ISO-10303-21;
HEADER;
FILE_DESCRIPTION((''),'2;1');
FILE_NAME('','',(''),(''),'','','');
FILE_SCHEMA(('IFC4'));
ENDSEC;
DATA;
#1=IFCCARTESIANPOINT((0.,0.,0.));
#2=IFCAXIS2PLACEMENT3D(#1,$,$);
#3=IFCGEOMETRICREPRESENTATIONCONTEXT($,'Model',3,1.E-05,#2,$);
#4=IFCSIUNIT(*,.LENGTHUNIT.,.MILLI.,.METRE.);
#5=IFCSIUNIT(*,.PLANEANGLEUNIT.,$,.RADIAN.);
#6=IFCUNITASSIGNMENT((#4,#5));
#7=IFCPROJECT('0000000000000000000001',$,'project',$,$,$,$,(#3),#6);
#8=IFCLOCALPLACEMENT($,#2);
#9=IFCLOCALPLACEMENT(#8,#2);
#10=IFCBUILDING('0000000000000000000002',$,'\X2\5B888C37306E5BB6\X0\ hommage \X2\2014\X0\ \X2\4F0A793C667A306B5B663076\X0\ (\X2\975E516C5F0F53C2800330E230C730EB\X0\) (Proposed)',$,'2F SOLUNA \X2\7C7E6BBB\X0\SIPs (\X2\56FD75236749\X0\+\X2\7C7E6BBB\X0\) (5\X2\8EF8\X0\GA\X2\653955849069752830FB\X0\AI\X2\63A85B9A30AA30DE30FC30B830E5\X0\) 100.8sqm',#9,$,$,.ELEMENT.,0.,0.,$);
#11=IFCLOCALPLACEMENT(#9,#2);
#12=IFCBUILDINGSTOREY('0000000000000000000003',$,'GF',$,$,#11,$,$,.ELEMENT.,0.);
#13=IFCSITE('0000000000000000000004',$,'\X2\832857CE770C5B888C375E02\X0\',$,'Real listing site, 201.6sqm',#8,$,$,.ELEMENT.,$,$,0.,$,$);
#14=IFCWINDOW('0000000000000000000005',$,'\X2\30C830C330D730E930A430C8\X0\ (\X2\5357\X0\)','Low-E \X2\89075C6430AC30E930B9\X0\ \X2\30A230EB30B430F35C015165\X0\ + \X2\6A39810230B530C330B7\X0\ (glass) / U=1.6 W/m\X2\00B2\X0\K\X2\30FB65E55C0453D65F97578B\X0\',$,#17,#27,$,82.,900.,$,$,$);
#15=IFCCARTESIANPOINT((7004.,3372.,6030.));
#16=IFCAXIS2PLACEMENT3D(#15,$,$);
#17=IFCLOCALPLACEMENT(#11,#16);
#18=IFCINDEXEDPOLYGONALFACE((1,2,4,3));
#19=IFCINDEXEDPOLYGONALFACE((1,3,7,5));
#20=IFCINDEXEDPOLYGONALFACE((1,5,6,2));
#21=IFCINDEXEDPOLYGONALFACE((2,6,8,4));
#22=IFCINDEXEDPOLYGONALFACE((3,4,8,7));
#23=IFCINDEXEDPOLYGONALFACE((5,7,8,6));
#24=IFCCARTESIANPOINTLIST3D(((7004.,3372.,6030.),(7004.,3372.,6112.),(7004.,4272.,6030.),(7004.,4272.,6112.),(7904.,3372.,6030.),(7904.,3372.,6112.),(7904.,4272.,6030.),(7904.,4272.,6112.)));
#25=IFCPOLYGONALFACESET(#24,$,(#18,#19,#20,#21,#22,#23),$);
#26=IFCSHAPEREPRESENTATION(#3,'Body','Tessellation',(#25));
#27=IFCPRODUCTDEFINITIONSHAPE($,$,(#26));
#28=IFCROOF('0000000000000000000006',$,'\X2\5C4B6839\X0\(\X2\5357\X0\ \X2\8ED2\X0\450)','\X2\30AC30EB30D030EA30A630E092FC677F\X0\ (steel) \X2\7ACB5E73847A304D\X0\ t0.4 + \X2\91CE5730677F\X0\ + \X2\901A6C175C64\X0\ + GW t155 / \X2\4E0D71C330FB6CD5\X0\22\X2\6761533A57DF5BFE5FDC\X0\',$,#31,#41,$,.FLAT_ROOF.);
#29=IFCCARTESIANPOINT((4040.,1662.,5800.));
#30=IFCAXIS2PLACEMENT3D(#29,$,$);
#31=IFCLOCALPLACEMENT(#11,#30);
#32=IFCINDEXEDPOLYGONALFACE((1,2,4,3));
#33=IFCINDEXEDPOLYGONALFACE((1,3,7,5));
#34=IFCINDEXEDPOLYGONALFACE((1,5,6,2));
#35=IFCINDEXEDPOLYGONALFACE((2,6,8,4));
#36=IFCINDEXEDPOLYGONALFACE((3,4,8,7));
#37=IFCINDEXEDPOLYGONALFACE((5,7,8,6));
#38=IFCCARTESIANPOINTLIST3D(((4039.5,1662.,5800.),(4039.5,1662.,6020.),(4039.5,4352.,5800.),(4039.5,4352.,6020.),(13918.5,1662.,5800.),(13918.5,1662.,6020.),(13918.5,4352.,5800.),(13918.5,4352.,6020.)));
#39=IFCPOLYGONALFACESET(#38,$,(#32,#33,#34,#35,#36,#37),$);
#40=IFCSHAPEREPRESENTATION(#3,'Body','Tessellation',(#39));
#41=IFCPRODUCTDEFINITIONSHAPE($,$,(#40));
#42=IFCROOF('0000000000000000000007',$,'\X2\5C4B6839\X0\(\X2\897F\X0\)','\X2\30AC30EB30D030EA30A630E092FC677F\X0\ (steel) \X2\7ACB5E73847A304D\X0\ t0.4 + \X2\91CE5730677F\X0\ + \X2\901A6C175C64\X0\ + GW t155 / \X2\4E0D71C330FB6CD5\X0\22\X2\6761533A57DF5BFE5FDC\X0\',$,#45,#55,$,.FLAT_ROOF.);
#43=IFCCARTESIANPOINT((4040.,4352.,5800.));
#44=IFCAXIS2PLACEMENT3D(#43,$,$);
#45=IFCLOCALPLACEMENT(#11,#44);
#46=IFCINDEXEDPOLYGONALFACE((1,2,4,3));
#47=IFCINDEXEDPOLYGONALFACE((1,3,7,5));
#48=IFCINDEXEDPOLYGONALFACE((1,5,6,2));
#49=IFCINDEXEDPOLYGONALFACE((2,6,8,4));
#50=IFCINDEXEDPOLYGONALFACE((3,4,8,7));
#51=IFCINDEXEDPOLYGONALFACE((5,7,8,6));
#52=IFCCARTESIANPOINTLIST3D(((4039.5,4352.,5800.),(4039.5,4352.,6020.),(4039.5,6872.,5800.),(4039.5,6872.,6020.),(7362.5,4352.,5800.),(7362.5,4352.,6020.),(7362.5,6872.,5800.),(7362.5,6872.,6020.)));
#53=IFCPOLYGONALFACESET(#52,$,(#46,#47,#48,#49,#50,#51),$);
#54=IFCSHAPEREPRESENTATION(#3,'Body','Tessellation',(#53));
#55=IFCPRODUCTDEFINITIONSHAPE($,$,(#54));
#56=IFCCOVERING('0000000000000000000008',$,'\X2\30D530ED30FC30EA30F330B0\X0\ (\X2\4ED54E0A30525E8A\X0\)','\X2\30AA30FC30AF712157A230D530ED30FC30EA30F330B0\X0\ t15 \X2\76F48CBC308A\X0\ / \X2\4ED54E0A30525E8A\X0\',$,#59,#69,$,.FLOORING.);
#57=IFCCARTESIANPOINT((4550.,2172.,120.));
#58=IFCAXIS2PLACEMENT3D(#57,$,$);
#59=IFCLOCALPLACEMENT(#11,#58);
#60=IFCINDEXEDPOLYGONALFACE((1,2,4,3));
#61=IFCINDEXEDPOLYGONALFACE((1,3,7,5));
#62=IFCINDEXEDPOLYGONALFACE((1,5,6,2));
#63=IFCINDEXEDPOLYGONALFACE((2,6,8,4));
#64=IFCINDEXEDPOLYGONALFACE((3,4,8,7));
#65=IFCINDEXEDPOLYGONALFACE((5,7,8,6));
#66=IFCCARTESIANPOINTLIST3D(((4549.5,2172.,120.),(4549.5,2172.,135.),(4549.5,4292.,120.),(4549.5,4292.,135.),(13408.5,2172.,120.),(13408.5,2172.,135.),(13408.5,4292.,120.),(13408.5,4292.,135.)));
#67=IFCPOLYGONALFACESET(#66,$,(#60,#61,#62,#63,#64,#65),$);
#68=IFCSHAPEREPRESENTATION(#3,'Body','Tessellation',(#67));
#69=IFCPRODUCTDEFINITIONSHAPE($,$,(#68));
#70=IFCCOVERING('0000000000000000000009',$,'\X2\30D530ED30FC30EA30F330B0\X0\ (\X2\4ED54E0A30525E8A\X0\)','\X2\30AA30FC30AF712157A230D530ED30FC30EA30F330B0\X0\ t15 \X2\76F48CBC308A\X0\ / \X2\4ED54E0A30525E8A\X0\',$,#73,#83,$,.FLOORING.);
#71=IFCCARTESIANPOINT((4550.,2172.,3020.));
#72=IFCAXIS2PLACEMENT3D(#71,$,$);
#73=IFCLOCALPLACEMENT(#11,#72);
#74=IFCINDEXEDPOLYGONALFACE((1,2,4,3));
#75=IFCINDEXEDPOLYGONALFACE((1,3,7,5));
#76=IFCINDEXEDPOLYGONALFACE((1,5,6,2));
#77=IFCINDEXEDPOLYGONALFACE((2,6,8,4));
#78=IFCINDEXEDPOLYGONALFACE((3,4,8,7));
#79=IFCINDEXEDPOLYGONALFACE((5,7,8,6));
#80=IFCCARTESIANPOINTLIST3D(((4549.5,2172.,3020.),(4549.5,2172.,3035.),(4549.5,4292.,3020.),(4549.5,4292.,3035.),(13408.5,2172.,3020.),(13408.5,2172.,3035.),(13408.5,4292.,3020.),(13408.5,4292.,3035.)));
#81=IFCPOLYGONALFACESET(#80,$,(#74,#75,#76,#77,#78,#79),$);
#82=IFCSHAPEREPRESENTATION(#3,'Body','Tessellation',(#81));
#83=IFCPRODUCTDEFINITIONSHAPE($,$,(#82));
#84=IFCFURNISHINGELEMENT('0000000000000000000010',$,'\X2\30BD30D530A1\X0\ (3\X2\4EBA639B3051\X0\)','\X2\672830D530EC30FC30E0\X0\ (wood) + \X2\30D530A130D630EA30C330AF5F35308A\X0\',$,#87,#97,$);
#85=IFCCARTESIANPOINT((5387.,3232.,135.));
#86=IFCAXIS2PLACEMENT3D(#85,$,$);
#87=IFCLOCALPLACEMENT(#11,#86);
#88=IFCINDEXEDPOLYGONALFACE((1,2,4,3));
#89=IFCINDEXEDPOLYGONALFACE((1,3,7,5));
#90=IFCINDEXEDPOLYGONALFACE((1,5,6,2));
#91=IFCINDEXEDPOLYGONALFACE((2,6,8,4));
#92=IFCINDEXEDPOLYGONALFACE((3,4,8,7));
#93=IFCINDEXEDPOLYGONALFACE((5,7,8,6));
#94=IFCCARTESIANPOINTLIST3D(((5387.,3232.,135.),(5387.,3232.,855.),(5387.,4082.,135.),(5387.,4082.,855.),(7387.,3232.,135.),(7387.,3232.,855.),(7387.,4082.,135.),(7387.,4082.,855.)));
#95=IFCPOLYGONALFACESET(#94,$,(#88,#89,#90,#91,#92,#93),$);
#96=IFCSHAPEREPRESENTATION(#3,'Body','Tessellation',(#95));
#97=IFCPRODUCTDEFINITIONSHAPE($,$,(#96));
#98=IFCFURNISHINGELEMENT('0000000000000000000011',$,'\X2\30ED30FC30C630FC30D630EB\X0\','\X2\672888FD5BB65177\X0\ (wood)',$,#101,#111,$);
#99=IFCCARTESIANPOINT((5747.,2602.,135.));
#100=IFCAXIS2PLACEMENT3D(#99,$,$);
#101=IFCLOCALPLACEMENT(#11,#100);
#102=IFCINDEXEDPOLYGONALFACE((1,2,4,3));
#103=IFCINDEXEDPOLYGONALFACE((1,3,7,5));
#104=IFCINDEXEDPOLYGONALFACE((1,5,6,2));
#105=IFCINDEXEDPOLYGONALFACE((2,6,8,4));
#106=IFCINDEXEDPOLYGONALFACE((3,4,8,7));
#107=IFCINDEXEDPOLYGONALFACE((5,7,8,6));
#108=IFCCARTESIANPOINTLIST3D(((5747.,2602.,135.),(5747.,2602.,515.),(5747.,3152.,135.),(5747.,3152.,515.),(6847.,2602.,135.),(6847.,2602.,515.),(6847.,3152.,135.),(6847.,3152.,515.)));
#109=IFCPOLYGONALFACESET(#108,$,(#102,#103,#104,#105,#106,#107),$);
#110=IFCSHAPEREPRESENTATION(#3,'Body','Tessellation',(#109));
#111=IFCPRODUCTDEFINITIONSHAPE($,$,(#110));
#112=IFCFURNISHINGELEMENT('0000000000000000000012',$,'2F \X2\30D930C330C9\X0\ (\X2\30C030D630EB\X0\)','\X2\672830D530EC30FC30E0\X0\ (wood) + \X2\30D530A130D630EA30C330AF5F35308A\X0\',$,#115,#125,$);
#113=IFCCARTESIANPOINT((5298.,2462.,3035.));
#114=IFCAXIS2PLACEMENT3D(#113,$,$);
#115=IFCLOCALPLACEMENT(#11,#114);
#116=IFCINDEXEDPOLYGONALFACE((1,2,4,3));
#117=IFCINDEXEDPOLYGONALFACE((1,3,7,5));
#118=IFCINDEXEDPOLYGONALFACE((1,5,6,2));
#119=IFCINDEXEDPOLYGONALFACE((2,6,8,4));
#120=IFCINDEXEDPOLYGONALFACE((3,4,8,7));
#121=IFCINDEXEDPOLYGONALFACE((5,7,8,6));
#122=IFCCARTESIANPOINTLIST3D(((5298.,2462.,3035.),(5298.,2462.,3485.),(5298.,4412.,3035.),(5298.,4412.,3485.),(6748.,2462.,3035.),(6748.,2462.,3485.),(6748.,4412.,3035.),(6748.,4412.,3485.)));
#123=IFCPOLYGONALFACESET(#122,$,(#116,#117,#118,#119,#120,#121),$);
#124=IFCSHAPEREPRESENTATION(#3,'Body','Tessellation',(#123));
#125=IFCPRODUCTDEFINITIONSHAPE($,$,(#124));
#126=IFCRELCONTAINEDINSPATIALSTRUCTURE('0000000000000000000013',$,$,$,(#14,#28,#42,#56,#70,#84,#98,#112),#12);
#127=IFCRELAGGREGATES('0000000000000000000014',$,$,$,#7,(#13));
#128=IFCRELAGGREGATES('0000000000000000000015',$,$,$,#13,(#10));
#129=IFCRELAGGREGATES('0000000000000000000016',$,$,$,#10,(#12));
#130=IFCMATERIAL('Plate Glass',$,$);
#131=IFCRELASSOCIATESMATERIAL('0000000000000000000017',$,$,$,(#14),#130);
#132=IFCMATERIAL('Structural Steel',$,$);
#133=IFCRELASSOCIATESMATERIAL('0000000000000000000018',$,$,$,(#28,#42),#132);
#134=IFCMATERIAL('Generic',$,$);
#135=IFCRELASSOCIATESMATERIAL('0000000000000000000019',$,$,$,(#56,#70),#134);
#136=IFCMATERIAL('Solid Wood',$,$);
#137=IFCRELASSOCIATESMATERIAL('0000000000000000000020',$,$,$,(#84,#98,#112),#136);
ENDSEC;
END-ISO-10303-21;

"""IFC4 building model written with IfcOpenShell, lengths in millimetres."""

from ifc_helpers import new_model, si_unit, frame, frame_2d, origin, place, context, project, spatial, rectangle, extrude, material, element, save


model = new_model("IFC4")

# Units and contexts
model_context = context("Model", 3, precision=1e-05, world=origin())
ifc_project = project(units=[si_unit("LENGTHUNIT", "METRE", prefix="MILLI"), si_unit("PLANEANGLEUNIT", "RADIAN")], contexts=[model_context])

# Site, building, storey
site_placement = place(None, origin())
site = spatial("IfcSite", under=ifc_project, at=site_placement, Name="茨城県守谷市", ObjectType="Real listing site, 201.6sqm", CompositionType="ELEMENT", RefElevation=0.0)
building_placement = place(site_placement, origin())
building = spatial("IfcBuilding", under=site, at=building_placement, Name="守谷の家 hommage — 伊礼智に学ぶ (非公式参考モデル) (Proposed)", ObjectType="2F SOLUNA 籾殻SIPs (国産杉+籾殻) (5軸GA改善適用・AI推定オマージュ) 100.8sqm", CompositionType="ELEMENT", ElevationOfRefHeight=0.0, ElevationOfTerrain=0.0)
storey_placement = place(building_placement, origin())
storey = spatial("IfcBuildingStorey", under=building, at=storey_placement, Name="GF", CompositionType="ELEMENT", Elevation=0.0)

# Shared definitions
ifc_material_1 = material(Name="Solid Wood")

# Shared definitions
ifc_material_2 = material(Name="Plate Glass")

# Window
window_1_placement = place(storey_placement, frame((7004.0, 3372.0, 6030.0)))
element("IfcWindow", 1, at=window_1_placement, inside=storey, material=ifc_material_2, Name="トップライト (南)", Description="Low-E 複層ガラス アルゴン封入 + 樹脂サッシ (glass) / U=1.6 W/m²K・日射取得型", OverallHeight=82.0, OverallWidth=900.0, context=model_context, shape_type="SweptSolid", body=[
    extrude(rectangle(XDim=900.0, YDim=900.0, at=frame_2d((450.0, 450.0))), frame((7004.0, 3372.0, 6030.0)), (0.0, 0.0, 1.0), 82.0),
])

# Roofs
ifc_material_3 = material(Name="Structural Steel")
roof_1_placement = place(storey_placement, frame((4040.0, 1662.0, 5800.0)))
element("IfcRoof", 2, at=roof_1_placement, inside=storey, material=ifc_material_3, Name="屋根(南 軒450)", Description="ガルバリウム鋼板 (steel) 立平葺き t0.4 + 野地板 + 通気層 + GW t155 / 不燃・法22条区域対応", PredefinedType="FLAT_ROOF", context=model_context, shape_type="SweptSolid", body=[
    extrude(rectangle(XDim=9879.0, YDim=2690.0, at=frame_2d((4939.0, 1345.0))), frame((4040.0, 1662.0, 5800.0)), (0.0, 0.0, 1.0), 220.0),
])
roof_2_placement = place(storey_placement, frame((4040.0, 4352.0, 5800.0)))
element("IfcRoof", 3, at=roof_2_placement, inside=storey, material=ifc_material_3, Name="屋根(西)", Description="ガルバリウム鋼板 (steel) 立平葺き t0.4 + 野地板 + 通気層 + GW t155 / 不燃・法22条区域対応", PredefinedType="FLAT_ROOF", context=model_context, shape_type="SweptSolid", body=[
    extrude(rectangle(XDim=3323.0, YDim=2520.0, at=frame_2d((1661.0, 1260.0))), frame((4040.0, 4352.0, 5800.0)), (0.0, 0.0, 1.0), 220.0),
])

# Coverings
ifc_material_4 = material(Name="Generic")
covering_1_placement = place(storey_placement, frame((4550.0, 2172.0, 120.0)))
element("IfcCovering", 4, at=covering_1_placement, inside=storey, material=ifc_material_4, Name="フローリング (仕上げ床)", Description="オーク無垢フローリング t15 直貼り / 仕上げ床", PredefinedType="FLOORING", context=model_context, shape_type="SweptSolid", body=[
    extrude(rectangle(XDim=8859.0, YDim=2120.0, at=frame_2d((4429.0, 1060.0))), frame((4550.0, 2172.0, 120.0)), (0.0, 0.0, 1.0), 15.0),
])
covering_2_placement = place(storey_placement, frame((4550.0, 2172.0, 3020.0)))
element("IfcCovering", 5, at=covering_2_placement, inside=storey, material=ifc_material_4, Name="フローリング (仕上げ床)", Description="オーク無垢フローリング t15 直貼り / 仕上げ床", PredefinedType="FLOORING", context=model_context, shape_type="SweptSolid", body=[
    extrude(rectangle(XDim=8859.0, YDim=2120.0, at=frame_2d((4429.0, 1060.0))), frame((4550.0, 2172.0, 3020.0)), (0.0, 0.0, 1.0), 15.0),
])

# Furnishing elements
furnishing_1_placement = place(storey_placement, frame((5387.0, 3232.0, 135.0)))
element("IfcFurnishingElement", 6, at=furnishing_1_placement, inside=storey, material=ifc_material_1, Name="ソファ (3人掛け)", Description="木フレーム (wood) + ファブリック張り", context=model_context, shape_type="SweptSolid", body=[
    extrude(rectangle(XDim=2000.0, YDim=850.0, at=frame_2d((1000.0, 425.0))), frame((5387.0, 3232.0, 135.0)), (0.0, 0.0, 1.0), 720.0),
])
furnishing_2_placement = place(storey_placement, frame((5747.0, 2602.0, 135.0)))
element("IfcFurnishingElement", 7, at=furnishing_2_placement, inside=storey, material=ifc_material_1, Name="ローテーブル", Description="木製家具 (wood)", context=model_context, shape_type="SweptSolid", body=[
    extrude(rectangle(XDim=1100.0, YDim=550.0, at=frame_2d((550.0, 275.0))), frame((5747.0, 2602.0, 135.0)), (0.0, 0.0, 1.0), 380.0),
])
furnishing_3_placement = place(storey_placement, frame((5298.0, 2462.0, 3035.0)))
element("IfcFurnishingElement", 8, at=furnishing_3_placement, inside=storey, material=ifc_material_1, Name="2F ベッド (ダブル)", Description="木フレーム (wood) + ファブリック張り", context=model_context, shape_type="SweptSolid", body=[
    extrude(rectangle(XDim=1450.0, YDim=1950.0, at=frame_2d((725.0, 975.0))), frame((5298.0, 2462.0, 3035.0)), (0.0, 0.0, 1.0), 450.0),
])

save(model, "model.ifc")
